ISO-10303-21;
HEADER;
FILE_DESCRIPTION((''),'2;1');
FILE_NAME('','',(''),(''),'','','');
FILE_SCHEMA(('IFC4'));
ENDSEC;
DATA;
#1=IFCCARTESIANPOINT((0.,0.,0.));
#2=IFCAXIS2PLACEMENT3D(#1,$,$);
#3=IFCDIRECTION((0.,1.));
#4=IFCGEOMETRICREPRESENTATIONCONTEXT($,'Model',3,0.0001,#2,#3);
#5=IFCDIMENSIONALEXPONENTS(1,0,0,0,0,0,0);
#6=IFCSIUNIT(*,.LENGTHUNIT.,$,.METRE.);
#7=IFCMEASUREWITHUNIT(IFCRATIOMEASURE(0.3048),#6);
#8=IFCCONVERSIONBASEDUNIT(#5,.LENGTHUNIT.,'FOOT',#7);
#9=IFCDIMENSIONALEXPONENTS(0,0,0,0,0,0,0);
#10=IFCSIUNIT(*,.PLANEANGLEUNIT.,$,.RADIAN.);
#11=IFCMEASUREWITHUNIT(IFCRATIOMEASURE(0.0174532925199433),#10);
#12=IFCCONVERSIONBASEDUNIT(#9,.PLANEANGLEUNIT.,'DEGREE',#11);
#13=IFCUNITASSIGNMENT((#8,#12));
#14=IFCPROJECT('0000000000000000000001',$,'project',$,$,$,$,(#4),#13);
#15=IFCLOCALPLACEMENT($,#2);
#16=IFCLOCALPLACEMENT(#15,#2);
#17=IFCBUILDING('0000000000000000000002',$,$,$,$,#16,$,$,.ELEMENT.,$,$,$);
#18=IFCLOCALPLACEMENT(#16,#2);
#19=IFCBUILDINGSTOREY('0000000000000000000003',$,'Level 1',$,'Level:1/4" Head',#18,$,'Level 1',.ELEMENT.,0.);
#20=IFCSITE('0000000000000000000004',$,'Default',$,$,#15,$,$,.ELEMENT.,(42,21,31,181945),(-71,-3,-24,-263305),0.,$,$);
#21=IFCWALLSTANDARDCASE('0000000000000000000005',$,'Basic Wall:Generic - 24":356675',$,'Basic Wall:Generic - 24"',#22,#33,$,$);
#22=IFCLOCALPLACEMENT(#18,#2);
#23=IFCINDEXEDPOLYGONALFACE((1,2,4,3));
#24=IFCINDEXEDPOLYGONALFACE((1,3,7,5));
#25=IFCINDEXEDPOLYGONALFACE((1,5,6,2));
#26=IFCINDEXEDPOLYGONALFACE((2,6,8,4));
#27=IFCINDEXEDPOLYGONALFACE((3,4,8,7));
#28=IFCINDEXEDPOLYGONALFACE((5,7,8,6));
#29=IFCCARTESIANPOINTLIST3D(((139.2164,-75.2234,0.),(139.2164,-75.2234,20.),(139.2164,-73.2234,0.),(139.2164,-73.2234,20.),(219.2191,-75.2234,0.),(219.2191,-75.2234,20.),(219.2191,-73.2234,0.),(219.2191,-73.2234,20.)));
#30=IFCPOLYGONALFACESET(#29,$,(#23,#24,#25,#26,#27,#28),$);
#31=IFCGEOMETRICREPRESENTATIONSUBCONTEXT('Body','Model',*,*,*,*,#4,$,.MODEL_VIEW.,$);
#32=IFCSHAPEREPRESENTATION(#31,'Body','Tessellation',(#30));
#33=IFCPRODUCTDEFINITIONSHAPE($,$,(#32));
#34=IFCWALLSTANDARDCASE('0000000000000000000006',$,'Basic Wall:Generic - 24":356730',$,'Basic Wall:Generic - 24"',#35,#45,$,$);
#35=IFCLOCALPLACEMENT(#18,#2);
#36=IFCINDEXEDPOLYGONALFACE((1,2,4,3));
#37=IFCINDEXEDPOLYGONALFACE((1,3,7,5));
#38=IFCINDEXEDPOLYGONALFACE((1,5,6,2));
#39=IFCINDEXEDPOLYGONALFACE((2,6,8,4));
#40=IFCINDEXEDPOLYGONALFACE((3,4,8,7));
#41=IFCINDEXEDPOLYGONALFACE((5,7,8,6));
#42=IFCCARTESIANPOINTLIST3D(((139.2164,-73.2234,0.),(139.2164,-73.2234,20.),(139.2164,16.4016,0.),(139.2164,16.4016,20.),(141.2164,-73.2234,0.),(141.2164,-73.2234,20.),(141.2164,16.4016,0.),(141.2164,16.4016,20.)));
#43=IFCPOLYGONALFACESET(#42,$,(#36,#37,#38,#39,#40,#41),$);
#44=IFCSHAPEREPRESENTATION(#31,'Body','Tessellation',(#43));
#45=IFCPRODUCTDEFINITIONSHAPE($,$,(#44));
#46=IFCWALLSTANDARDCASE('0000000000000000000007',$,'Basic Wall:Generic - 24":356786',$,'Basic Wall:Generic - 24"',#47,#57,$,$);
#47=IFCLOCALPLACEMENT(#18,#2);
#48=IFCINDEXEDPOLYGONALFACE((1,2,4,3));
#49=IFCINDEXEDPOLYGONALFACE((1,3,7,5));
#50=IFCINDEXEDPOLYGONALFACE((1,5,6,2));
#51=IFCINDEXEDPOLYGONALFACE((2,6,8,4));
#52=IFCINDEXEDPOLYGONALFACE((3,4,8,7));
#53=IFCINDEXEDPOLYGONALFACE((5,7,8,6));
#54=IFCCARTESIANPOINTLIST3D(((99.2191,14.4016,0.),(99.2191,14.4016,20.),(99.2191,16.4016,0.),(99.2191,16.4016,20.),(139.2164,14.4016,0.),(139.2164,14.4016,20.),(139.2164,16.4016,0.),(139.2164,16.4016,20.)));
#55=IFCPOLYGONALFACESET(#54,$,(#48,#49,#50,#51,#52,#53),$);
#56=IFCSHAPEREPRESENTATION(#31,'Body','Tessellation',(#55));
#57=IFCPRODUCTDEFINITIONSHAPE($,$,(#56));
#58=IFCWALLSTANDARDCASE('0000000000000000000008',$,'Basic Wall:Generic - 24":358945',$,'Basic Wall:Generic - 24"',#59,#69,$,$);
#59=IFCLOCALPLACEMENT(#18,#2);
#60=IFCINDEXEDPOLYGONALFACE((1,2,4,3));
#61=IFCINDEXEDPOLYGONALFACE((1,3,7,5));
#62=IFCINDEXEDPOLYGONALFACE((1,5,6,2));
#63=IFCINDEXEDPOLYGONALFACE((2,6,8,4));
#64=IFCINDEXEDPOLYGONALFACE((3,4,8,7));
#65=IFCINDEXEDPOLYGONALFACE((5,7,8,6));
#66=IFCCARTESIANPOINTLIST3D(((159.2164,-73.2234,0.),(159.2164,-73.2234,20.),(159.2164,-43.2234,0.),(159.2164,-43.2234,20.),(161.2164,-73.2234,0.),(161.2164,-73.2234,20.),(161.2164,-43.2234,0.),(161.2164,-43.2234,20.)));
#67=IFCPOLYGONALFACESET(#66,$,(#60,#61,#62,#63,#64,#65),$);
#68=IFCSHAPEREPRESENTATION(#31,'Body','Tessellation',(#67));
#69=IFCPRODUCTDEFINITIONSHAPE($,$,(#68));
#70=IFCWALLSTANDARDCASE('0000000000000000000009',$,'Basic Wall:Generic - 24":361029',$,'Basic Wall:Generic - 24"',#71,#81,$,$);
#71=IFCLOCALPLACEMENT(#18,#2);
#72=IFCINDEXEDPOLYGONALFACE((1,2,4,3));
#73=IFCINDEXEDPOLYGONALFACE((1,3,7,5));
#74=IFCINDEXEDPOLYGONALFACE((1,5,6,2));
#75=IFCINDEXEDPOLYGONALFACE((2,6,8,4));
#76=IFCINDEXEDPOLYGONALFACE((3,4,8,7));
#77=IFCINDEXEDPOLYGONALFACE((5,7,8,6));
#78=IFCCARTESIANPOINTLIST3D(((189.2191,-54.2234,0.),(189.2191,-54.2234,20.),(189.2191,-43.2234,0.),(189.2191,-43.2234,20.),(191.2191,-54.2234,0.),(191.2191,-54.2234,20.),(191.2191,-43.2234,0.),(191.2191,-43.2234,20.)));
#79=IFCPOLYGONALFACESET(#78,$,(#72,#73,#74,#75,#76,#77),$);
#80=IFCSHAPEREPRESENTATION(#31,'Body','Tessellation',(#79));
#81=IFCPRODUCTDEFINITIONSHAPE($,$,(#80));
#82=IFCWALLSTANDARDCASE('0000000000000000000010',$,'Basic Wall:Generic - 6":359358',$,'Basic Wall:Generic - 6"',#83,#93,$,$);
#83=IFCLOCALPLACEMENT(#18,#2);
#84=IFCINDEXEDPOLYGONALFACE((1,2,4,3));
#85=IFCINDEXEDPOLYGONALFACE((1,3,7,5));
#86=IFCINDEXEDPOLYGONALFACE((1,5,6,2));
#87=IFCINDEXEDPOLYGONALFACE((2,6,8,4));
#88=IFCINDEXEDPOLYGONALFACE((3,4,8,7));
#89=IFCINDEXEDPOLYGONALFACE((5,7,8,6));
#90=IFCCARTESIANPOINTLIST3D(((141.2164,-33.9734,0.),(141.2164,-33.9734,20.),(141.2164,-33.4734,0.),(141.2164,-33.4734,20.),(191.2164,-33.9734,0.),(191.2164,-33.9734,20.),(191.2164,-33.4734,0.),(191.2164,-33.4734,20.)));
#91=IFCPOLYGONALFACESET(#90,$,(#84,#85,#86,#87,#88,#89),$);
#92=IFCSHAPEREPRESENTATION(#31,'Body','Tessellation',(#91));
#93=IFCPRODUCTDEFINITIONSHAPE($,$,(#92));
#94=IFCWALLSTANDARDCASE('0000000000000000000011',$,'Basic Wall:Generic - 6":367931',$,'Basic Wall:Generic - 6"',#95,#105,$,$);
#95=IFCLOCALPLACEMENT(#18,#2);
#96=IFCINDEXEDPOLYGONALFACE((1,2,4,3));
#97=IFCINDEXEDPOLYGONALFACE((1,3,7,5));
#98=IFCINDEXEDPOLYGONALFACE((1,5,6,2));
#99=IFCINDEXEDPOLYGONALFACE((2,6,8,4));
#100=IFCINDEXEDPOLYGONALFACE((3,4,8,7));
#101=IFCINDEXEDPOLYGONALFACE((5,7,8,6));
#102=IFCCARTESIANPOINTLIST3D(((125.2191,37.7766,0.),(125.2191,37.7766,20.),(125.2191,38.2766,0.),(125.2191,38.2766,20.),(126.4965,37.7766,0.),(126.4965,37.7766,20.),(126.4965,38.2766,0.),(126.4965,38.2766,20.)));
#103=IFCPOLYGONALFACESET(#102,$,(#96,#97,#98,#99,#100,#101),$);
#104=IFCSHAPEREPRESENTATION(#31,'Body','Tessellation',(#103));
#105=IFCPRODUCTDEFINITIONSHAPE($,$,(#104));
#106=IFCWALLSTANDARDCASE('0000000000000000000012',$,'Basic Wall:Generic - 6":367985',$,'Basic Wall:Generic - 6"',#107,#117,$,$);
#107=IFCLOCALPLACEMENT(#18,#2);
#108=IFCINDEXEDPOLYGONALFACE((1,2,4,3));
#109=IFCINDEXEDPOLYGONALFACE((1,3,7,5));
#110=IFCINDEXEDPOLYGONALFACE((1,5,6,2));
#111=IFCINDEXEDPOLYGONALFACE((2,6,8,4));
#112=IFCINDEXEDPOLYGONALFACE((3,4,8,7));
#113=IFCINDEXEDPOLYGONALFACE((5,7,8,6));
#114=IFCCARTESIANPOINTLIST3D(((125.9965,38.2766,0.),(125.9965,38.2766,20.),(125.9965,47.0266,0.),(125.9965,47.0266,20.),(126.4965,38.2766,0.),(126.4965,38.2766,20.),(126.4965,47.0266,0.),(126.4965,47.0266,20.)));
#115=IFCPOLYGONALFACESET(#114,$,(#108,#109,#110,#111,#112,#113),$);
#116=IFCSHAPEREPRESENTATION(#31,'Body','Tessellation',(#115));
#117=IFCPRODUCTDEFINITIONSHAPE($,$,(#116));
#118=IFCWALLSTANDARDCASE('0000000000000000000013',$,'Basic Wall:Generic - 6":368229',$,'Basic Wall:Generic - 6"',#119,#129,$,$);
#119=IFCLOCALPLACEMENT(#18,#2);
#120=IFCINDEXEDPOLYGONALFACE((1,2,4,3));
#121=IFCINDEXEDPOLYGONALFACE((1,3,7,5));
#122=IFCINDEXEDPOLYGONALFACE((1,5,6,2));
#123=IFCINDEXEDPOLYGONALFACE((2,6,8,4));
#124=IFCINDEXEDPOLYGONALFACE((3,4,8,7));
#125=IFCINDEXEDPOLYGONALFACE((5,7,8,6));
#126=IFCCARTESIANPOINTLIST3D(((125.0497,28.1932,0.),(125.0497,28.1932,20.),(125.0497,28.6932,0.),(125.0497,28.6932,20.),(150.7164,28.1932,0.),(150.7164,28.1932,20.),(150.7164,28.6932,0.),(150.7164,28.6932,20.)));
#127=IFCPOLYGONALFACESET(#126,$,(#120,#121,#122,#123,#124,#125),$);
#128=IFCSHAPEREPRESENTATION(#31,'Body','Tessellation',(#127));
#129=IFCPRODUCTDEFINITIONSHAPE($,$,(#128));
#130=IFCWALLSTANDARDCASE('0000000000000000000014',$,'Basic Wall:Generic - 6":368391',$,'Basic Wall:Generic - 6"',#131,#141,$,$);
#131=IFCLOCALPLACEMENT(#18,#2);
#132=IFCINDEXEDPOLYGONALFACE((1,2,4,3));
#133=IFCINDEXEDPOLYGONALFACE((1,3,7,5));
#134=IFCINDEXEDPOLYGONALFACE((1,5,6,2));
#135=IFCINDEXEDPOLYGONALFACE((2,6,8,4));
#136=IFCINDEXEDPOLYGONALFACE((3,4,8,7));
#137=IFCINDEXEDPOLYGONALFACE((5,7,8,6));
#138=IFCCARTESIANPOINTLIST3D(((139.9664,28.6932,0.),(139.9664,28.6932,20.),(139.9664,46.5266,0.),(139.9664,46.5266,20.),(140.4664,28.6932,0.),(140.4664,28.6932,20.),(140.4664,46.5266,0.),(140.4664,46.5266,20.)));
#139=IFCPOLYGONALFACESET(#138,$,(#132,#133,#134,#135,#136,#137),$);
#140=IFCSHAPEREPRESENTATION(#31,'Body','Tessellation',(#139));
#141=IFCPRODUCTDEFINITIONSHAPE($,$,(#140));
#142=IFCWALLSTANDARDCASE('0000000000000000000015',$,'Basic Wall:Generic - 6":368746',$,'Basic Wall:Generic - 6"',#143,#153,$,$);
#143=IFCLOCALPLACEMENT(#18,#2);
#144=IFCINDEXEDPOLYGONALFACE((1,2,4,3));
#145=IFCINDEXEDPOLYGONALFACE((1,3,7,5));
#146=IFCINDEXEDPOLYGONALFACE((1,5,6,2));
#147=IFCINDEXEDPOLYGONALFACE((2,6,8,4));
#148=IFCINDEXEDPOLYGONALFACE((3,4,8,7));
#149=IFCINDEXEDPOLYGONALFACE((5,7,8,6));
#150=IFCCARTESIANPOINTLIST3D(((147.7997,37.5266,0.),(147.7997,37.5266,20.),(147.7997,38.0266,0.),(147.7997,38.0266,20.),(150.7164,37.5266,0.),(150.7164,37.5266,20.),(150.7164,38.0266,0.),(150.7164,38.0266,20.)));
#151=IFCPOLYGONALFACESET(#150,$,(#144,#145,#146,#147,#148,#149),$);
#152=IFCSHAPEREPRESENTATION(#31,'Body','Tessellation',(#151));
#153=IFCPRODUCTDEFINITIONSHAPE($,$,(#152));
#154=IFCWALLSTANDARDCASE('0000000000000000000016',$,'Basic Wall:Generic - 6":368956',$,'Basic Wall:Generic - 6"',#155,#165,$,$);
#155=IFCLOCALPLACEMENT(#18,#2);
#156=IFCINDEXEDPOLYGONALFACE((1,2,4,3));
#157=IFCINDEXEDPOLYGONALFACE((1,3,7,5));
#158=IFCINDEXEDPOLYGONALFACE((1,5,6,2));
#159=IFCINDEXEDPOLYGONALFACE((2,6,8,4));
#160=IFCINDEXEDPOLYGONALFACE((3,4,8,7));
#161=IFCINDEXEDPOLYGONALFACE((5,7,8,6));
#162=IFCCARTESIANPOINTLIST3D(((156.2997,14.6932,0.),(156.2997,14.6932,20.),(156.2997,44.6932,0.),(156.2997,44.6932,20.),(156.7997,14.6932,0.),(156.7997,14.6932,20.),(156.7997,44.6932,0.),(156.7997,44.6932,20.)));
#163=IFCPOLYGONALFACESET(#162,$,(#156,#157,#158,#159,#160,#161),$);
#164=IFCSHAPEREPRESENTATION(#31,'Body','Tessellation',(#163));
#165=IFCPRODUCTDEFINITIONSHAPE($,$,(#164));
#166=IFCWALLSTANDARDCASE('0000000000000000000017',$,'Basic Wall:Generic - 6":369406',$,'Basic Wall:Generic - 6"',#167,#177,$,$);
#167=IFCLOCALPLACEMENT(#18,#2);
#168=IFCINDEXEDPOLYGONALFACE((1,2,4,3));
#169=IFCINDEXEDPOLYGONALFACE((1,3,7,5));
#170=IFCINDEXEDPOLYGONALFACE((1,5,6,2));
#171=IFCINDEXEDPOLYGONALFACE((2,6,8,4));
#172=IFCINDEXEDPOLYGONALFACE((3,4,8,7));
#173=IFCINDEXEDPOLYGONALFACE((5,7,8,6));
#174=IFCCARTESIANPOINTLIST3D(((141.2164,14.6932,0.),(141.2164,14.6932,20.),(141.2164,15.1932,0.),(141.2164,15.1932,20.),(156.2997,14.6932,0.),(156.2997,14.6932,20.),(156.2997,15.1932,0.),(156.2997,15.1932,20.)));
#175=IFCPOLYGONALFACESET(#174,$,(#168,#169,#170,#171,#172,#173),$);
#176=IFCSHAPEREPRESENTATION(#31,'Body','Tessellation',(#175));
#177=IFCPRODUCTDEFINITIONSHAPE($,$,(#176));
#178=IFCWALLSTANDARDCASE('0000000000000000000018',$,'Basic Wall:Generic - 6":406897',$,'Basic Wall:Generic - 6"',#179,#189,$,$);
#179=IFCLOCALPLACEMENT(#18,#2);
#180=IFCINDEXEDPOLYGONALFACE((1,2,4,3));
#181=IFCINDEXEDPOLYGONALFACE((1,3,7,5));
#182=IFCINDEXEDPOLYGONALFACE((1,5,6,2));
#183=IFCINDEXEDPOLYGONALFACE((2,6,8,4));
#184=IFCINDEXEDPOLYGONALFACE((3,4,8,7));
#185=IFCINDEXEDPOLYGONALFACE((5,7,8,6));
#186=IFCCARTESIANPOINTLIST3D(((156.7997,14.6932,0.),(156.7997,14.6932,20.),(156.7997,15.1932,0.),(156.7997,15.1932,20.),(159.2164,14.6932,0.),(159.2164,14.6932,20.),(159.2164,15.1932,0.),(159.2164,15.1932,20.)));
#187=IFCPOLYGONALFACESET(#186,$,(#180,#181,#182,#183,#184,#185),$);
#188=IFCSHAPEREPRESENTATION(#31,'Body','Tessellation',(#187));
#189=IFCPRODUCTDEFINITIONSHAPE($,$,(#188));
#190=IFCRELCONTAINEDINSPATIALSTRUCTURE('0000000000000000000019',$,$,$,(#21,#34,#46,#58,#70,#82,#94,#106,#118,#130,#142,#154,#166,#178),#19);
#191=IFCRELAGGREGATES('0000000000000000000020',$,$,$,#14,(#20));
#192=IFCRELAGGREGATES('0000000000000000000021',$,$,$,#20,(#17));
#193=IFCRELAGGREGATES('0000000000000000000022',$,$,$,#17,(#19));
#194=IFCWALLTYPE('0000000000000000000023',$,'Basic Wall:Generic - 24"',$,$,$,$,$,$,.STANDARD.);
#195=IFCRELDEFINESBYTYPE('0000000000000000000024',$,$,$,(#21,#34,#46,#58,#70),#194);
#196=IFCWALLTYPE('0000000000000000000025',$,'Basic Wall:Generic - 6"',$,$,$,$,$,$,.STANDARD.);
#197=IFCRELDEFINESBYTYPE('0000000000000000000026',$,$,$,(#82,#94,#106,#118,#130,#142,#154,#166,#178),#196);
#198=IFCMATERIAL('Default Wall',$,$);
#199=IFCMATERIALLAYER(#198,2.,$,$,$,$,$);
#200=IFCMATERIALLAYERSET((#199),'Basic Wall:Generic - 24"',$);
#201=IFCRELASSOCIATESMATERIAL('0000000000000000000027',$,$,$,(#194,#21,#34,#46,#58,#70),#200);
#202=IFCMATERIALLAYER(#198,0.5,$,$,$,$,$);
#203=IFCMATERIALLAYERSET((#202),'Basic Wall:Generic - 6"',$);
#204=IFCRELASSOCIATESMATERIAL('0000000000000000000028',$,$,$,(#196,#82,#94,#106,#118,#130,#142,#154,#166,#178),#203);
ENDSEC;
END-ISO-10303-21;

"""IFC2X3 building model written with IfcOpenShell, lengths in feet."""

from ifc_helpers import new_model, entity, si_unit, converted_unit, direction, frame, frame_2d, origin, place, context, subcontext, project, spatial, rectangle, extrude, material, layer, layer_set, layer_usage, type_object, element, save


model = new_model("IFC2X3")

# Units and contexts
model_context = context("Model", 3, precision=0.0001, world=origin(), true_north=direction((0.0, 1.0)))
body_context = subcontext(model_context, "Body", "Model", "MODEL_VIEW")
ifc_project = project(units=[converted_unit("LENGTHUNIT", "FOOT", entity("IfcRatioMeasure", 0.3048), si_unit("LENGTHUNIT", "METRE"), dimensions=[1, 0, 0, 0, 0, 0, 0]), converted_unit("PLANEANGLEUNIT", "DEGREE", entity("IfcRatioMeasure", 0.0174532925199433), si_unit("PLANEANGLEUNIT", "RADIAN"), dimensions=[0, 0, 0, 0, 0, 0, 0])], contexts=[model_context])

# Site, building, storey
site_placement = place(None, origin())
site = spatial("IfcSite", under=ifc_project, at=site_placement, Name="Default", CompositionType="ELEMENT", RefLatitude=(42, 21, 31, 181945), RefLongitude=(-71, -3, -24, -263305), RefElevation=0.0)
building_placement = place(site_placement, origin())
building = spatial("IfcBuilding", under=site, at=building_placement, CompositionType="ELEMENT")
storey_placement = place(building_placement, origin())
storey = spatial("IfcBuildingStorey", under=building, at=storey_placement, Name="Level 1", ObjectType="Level:1/4\" Head", LongName="Level 1", CompositionType="ELEMENT", Elevation=0.0)

# Walls
ifc_material = material(Name="Default Wall")
ifc_layer_1 = layer(ifc_material, 2.0)
ifc_layer_set_1 = layer_set([ifc_layer_1], Name="Basic Wall:Generic - 24\"")
ifc_layer_usage_1 = layer_usage(ifc_layer_set_1, "AXIS2", "NEGATIVE", 1.0)
wall_type_1 = type_object("IfcWallType", Name="Basic Wall:Generic - 24\"", PredefinedType="STANDARD", material=ifc_layer_set_1)
wall_1_placement = place(storey_placement, frame((219.2191, -74.2234, 0.0), z_axis=(0.0, 0.0, 1.0), x_axis=(-1.0, 0.0, 0.0)))
element("IfcWallStandardCase", 1, at=wall_1_placement, inside=storey, type_object=wall_type_1, material=ifc_layer_usage_1, Name="Basic Wall:Generic - 24\":356675", ObjectType="Basic Wall:Generic - 24\"", context=body_context, shape_type="SweptSolid", body=[
    extrude(rectangle(XDim=80.0028, YDim=2.0, at=frame_2d((40.0014, 0.0), x_axis=(-1.0, 0.0))), origin(), (0.0, 0.0, 1.0), 20.0),
])
ifc_layer_usage_2 = layer_usage(ifc_layer_set_1, "AXIS2", "NEGATIVE", 1.0)
wall_2_placement = place(storey_placement, frame((140.2164, -73.2234, 0.0), z_axis=(0.0, 0.0, 1.0), x_axis=(0.0, 1.0, 0.0)))
element("IfcWallStandardCase", 2, at=wall_2_placement, inside=storey, type_object=wall_type_1, material=ifc_layer_usage_2, Name="Basic Wall:Generic - 24\":356730", ObjectType="Basic Wall:Generic - 24\"", context=body_context, shape_type="SweptSolid", body=[
    extrude(rectangle(XDim=89.625, YDim=2.0, at=frame_2d((44.8125, 0.0), x_axis=(-1.0, 0.0))), origin(), (0.0, 0.0, 1.0), 20.0),
])
ifc_layer_usage_3 = layer_usage(ifc_layer_set_1, "AXIS2", "NEGATIVE", 1.0)
wall_3_placement = place(storey_placement, frame((139.2164, 15.4016, 0.0), z_axis=(0.0, 0.0, 1.0), x_axis=(-1.0, 0.0, 0.0)))
element("IfcWallStandardCase", 3, at=wall_3_placement, inside=storey, type_object=wall_type_1, material=ifc_layer_usage_3, Name="Basic Wall:Generic - 24\":356786", ObjectType="Basic Wall:Generic - 24\"", context=body_context, shape_type="SweptSolid", body=[
    extrude(rectangle(XDim=39.9972, YDim=2.0, at=frame_2d((19.9986, 0.0), x_axis=(-1.0, 0.0))), origin(), (0.0, 0.0, 1.0), 20.0),
])
ifc_layer_usage_4 = layer_usage(ifc_layer_set_1, "AXIS2", "NEGATIVE", 1.0)
wall_4_placement = place(storey_placement, frame((160.2164, -73.2234, 0.0), z_axis=(0.0, 0.0, 1.0), x_axis=(0.0, 1.0, 0.0)))
element("IfcWallStandardCase", 4, at=wall_4_placement, inside=storey, type_object=wall_type_1, material=ifc_layer_usage_4, Name="Basic Wall:Generic - 24\":358945", ObjectType="Basic Wall:Generic - 24\"", context=body_context, shape_type="SweptSolid", body=[
    extrude(rectangle(XDim=30.0, YDim=2.0, at=frame_2d((15.0, 0.0), x_axis=(-1.0, 0.0))), origin(), (0.0, 0.0, 1.0), 20.0),
])
ifc_layer_usage_5 = layer_usage(ifc_layer_set_1, "AXIS2", "NEGATIVE", 1.0)
wall_5_placement = place(storey_placement, frame((190.2191, -54.2234, 0.0), z_axis=(0.0, 0.0, 1.0), x_axis=(0.0, 1.0, 0.0)))
element("IfcWallStandardCase", 5, at=wall_5_placement, inside=storey, type_object=wall_type_1, material=ifc_layer_usage_5, Name="Basic Wall:Generic - 24\":361029", ObjectType="Basic Wall:Generic - 24\"", context=body_context, shape_type="SweptSolid", body=[
    extrude(rectangle(XDim=11.0, YDim=2.0, at=frame_2d((5.5, 0.0), x_axis=(-1.0, 0.0))), origin(), (0.0, 0.0, 1.0), 20.0),
])
ifc_layer_2 = layer(ifc_material, 0.5)
ifc_layer_set_2 = layer_set([ifc_layer_2], Name="Basic Wall:Generic - 6\"")
ifc_layer_usage_6 = layer_usage(ifc_layer_set_2, "AXIS2", "NEGATIVE", 0.25)
wall_type_2 = type_object("IfcWallType", Name="Basic Wall:Generic - 6\"", PredefinedType="STANDARD", material=ifc_layer_set_2)
wall_6_placement = place(storey_placement, frame((141.2164, -33.7234, 0.0)))
element("IfcWallStandardCase", 6, at=wall_6_placement, inside=storey, type_object=wall_type_2, material=ifc_layer_usage_6, Name="Basic Wall:Generic - 6\":359358", ObjectType="Basic Wall:Generic - 6\"", context=body_context, shape_type="SweptSolid", body=[
    extrude(rectangle(XDim=50.0, YDim=0.5, at=frame_2d((25.0, 0.0), x_axis=(-1.0, 0.0))), origin(), (0.0, 0.0, 1.0), 20.0),
])
ifc_layer_usage_7 = layer_usage(ifc_layer_set_2, "AXIS2", "NEGATIVE", 0.25)
wall_7_placement = place(storey_placement, frame((125.2191, 38.0266, 0.0)))
element("IfcWallStandardCase", 7, at=wall_7_placement, inside=storey, type_object=wall_type_2, material=ifc_layer_usage_7, Name="Basic Wall:Generic - 6\":367931", ObjectType="Basic Wall:Generic - 6\"", context=body_context, shape_type="SweptSolid", body=[
    extrude(rectangle(XDim=1.2774, YDim=0.5, at=frame_2d((0.6387, 0.0), x_axis=(-1.0, 0.0))), origin(), (0.0, 0.0, 1.0), 20.0),
])
ifc_layer_usage_8 = layer_usage(ifc_layer_set_2, "AXIS2", "NEGATIVE", 0.25)
wall_8_placement = place(storey_placement, frame((126.2465, 38.2766, 0.0), z_axis=(0.0, 0.0, 1.0), x_axis=(0.0, 1.0, 0.0)))
element("IfcWallStandardCase", 8, at=wall_8_placement, inside=storey, type_object=wall_type_2, material=ifc_layer_usage_8, Name="Basic Wall:Generic - 6\":367985", ObjectType="Basic Wall:Generic - 6\"", context=body_context, shape_type="SweptSolid", body=[
    extrude(rectangle(XDim=8.75, YDim=0.5, at=frame_2d((4.375, 0.0), x_axis=(-1.0, 0.0))), origin(), (0.0, 0.0, 1.0), 20.0),
])
ifc_layer_usage_9 = layer_usage(ifc_layer_set_2, "AXIS2", "NEGATIVE", 0.25)
wall_9_placement = place(storey_placement, frame((150.7164, 28.4432, 0.0), z_axis=(0.0, 0.0, 1.0), x_axis=(-1.0, 0.0, 0.0)))
element("IfcWallStandardCase", 9, at=wall_9_placement, inside=storey, type_object=wall_type_2, material=ifc_layer_usage_9, Name="Basic Wall:Generic - 6\":368229", ObjectType="Basic Wall:Generic - 6\"", context=body_context, shape_type="SweptSolid", body=[
    extrude(rectangle(XDim=25.6667, YDim=0.5, at=frame_2d((12.8333, 0.0), x_axis=(-1.0, 0.0))), origin(), (0.0, 0.0, 1.0), 20.0),
])
ifc_layer_usage_10 = layer_usage(ifc_layer_set_2, "AXIS2", "NEGATIVE", 0.25)
wall_10_placement = place(storey_placement, frame((140.2164, 28.6932, 0.0), z_axis=(0.0, 0.0, 1.0), x_axis=(0.0, 1.0, 0.0)))
element("IfcWallStandardCase", 10, at=wall_10_placement, inside=storey, type_object=wall_type_2, material=ifc_layer_usage_10, Name="Basic Wall:Generic - 6\":368391", ObjectType="Basic Wall:Generic - 6\"", context=body_context, shape_type="SweptSolid", body=[
    extrude(rectangle(XDim=17.8333, YDim=0.5, at=frame_2d((8.9167, 0.0), x_axis=(-1.0, 0.0))), origin(), (0.0, 0.0, 1.0), 20.0),
])
ifc_layer_usage_11 = layer_usage(ifc_layer_set_2, "AXIS2", "NEGATIVE", 0.25)
wall_11_placement = place(storey_placement, frame((150.7164, 37.7766, 0.0), z_axis=(0.0, 0.0, 1.0), x_axis=(-1.0, 0.0, 0.0)))
element("IfcWallStandardCase", 11, at=wall_11_placement, inside=storey, type_object=wall_type_2, material=ifc_layer_usage_11, Name="Basic Wall:Generic - 6\":368746", ObjectType="Basic Wall:Generic - 6\"", context=body_context, shape_type="SweptSolid", body=[
    extrude(rectangle(XDim=2.9167, YDim=0.5, at=frame_2d((1.4583, 0.0), x_axis=(-1.0, 0.0))), origin(), (0.0, 0.0, 1.0), 20.0),
])
ifc_layer_usage_12 = layer_usage(ifc_layer_set_2, "AXIS2", "NEGATIVE", 0.25)
wall_12_placement = place(storey_placement, frame((156.5497, 44.6932, 0.0), z_axis=(0.0, 0.0, 1.0), x_axis=(0.0, -1.0, 0.0)))
element("IfcWallStandardCase", 12, at=wall_12_placement, inside=storey, type_object=wall_type_2, material=ifc_layer_usage_12, Name="Basic Wall:Generic - 6\":368956", ObjectType="Basic Wall:Generic - 6\"", context=body_context, shape_type="SweptSolid", body=[
    extrude(rectangle(XDim=30.0, YDim=0.5, at=frame_2d((15.0, 0.0), x_axis=(-1.0, 0.0))), origin(), (0.0, 0.0, 1.0), 20.0),
])
ifc_layer_usage_13 = layer_usage(ifc_layer_set_2, "AXIS2", "NEGATIVE", 0.25)
wall_13_placement = place(storey_placement, frame((156.2997, 14.9432, 0.0), z_axis=(0.0, 0.0, 1.0), x_axis=(-1.0, 0.0, 0.0)))
element("IfcWallStandardCase", 13, at=wall_13_placement, inside=storey, type_object=wall_type_2, material=ifc_layer_usage_13, Name="Basic Wall:Generic - 6\":369406", ObjectType="Basic Wall:Generic - 6\"", context=body_context, shape_type="SweptSolid", body=[
    extrude(rectangle(XDim=15.0833, YDim=0.5, at=frame_2d((7.5417, 0.0), x_axis=(-1.0, 0.0))), origin(), (0.0, 0.0, 1.0), 20.0),
])
ifc_layer_usage_14 = layer_usage(ifc_layer_set_2, "AXIS2", "NEGATIVE", 0.25)
wall_14_placement = place(storey_placement, frame((156.7997, 14.9432, 0.0)))
element("IfcWallStandardCase", 14, at=wall_14_placement, inside=storey, type_object=wall_type_2, material=ifc_layer_usage_14, Name="Basic Wall:Generic - 6\":406897", ObjectType="Basic Wall:Generic - 6\"", context=body_context, shape_type="SweptSolid", body=[
    extrude(rectangle(XDim=2.4167, YDim=0.5, at=frame_2d((1.2083, 0.0), x_axis=(-1.0, 0.0))), origin(), (0.0, 0.0, 1.0), 20.0),
])

save(model, "model.ifc")
